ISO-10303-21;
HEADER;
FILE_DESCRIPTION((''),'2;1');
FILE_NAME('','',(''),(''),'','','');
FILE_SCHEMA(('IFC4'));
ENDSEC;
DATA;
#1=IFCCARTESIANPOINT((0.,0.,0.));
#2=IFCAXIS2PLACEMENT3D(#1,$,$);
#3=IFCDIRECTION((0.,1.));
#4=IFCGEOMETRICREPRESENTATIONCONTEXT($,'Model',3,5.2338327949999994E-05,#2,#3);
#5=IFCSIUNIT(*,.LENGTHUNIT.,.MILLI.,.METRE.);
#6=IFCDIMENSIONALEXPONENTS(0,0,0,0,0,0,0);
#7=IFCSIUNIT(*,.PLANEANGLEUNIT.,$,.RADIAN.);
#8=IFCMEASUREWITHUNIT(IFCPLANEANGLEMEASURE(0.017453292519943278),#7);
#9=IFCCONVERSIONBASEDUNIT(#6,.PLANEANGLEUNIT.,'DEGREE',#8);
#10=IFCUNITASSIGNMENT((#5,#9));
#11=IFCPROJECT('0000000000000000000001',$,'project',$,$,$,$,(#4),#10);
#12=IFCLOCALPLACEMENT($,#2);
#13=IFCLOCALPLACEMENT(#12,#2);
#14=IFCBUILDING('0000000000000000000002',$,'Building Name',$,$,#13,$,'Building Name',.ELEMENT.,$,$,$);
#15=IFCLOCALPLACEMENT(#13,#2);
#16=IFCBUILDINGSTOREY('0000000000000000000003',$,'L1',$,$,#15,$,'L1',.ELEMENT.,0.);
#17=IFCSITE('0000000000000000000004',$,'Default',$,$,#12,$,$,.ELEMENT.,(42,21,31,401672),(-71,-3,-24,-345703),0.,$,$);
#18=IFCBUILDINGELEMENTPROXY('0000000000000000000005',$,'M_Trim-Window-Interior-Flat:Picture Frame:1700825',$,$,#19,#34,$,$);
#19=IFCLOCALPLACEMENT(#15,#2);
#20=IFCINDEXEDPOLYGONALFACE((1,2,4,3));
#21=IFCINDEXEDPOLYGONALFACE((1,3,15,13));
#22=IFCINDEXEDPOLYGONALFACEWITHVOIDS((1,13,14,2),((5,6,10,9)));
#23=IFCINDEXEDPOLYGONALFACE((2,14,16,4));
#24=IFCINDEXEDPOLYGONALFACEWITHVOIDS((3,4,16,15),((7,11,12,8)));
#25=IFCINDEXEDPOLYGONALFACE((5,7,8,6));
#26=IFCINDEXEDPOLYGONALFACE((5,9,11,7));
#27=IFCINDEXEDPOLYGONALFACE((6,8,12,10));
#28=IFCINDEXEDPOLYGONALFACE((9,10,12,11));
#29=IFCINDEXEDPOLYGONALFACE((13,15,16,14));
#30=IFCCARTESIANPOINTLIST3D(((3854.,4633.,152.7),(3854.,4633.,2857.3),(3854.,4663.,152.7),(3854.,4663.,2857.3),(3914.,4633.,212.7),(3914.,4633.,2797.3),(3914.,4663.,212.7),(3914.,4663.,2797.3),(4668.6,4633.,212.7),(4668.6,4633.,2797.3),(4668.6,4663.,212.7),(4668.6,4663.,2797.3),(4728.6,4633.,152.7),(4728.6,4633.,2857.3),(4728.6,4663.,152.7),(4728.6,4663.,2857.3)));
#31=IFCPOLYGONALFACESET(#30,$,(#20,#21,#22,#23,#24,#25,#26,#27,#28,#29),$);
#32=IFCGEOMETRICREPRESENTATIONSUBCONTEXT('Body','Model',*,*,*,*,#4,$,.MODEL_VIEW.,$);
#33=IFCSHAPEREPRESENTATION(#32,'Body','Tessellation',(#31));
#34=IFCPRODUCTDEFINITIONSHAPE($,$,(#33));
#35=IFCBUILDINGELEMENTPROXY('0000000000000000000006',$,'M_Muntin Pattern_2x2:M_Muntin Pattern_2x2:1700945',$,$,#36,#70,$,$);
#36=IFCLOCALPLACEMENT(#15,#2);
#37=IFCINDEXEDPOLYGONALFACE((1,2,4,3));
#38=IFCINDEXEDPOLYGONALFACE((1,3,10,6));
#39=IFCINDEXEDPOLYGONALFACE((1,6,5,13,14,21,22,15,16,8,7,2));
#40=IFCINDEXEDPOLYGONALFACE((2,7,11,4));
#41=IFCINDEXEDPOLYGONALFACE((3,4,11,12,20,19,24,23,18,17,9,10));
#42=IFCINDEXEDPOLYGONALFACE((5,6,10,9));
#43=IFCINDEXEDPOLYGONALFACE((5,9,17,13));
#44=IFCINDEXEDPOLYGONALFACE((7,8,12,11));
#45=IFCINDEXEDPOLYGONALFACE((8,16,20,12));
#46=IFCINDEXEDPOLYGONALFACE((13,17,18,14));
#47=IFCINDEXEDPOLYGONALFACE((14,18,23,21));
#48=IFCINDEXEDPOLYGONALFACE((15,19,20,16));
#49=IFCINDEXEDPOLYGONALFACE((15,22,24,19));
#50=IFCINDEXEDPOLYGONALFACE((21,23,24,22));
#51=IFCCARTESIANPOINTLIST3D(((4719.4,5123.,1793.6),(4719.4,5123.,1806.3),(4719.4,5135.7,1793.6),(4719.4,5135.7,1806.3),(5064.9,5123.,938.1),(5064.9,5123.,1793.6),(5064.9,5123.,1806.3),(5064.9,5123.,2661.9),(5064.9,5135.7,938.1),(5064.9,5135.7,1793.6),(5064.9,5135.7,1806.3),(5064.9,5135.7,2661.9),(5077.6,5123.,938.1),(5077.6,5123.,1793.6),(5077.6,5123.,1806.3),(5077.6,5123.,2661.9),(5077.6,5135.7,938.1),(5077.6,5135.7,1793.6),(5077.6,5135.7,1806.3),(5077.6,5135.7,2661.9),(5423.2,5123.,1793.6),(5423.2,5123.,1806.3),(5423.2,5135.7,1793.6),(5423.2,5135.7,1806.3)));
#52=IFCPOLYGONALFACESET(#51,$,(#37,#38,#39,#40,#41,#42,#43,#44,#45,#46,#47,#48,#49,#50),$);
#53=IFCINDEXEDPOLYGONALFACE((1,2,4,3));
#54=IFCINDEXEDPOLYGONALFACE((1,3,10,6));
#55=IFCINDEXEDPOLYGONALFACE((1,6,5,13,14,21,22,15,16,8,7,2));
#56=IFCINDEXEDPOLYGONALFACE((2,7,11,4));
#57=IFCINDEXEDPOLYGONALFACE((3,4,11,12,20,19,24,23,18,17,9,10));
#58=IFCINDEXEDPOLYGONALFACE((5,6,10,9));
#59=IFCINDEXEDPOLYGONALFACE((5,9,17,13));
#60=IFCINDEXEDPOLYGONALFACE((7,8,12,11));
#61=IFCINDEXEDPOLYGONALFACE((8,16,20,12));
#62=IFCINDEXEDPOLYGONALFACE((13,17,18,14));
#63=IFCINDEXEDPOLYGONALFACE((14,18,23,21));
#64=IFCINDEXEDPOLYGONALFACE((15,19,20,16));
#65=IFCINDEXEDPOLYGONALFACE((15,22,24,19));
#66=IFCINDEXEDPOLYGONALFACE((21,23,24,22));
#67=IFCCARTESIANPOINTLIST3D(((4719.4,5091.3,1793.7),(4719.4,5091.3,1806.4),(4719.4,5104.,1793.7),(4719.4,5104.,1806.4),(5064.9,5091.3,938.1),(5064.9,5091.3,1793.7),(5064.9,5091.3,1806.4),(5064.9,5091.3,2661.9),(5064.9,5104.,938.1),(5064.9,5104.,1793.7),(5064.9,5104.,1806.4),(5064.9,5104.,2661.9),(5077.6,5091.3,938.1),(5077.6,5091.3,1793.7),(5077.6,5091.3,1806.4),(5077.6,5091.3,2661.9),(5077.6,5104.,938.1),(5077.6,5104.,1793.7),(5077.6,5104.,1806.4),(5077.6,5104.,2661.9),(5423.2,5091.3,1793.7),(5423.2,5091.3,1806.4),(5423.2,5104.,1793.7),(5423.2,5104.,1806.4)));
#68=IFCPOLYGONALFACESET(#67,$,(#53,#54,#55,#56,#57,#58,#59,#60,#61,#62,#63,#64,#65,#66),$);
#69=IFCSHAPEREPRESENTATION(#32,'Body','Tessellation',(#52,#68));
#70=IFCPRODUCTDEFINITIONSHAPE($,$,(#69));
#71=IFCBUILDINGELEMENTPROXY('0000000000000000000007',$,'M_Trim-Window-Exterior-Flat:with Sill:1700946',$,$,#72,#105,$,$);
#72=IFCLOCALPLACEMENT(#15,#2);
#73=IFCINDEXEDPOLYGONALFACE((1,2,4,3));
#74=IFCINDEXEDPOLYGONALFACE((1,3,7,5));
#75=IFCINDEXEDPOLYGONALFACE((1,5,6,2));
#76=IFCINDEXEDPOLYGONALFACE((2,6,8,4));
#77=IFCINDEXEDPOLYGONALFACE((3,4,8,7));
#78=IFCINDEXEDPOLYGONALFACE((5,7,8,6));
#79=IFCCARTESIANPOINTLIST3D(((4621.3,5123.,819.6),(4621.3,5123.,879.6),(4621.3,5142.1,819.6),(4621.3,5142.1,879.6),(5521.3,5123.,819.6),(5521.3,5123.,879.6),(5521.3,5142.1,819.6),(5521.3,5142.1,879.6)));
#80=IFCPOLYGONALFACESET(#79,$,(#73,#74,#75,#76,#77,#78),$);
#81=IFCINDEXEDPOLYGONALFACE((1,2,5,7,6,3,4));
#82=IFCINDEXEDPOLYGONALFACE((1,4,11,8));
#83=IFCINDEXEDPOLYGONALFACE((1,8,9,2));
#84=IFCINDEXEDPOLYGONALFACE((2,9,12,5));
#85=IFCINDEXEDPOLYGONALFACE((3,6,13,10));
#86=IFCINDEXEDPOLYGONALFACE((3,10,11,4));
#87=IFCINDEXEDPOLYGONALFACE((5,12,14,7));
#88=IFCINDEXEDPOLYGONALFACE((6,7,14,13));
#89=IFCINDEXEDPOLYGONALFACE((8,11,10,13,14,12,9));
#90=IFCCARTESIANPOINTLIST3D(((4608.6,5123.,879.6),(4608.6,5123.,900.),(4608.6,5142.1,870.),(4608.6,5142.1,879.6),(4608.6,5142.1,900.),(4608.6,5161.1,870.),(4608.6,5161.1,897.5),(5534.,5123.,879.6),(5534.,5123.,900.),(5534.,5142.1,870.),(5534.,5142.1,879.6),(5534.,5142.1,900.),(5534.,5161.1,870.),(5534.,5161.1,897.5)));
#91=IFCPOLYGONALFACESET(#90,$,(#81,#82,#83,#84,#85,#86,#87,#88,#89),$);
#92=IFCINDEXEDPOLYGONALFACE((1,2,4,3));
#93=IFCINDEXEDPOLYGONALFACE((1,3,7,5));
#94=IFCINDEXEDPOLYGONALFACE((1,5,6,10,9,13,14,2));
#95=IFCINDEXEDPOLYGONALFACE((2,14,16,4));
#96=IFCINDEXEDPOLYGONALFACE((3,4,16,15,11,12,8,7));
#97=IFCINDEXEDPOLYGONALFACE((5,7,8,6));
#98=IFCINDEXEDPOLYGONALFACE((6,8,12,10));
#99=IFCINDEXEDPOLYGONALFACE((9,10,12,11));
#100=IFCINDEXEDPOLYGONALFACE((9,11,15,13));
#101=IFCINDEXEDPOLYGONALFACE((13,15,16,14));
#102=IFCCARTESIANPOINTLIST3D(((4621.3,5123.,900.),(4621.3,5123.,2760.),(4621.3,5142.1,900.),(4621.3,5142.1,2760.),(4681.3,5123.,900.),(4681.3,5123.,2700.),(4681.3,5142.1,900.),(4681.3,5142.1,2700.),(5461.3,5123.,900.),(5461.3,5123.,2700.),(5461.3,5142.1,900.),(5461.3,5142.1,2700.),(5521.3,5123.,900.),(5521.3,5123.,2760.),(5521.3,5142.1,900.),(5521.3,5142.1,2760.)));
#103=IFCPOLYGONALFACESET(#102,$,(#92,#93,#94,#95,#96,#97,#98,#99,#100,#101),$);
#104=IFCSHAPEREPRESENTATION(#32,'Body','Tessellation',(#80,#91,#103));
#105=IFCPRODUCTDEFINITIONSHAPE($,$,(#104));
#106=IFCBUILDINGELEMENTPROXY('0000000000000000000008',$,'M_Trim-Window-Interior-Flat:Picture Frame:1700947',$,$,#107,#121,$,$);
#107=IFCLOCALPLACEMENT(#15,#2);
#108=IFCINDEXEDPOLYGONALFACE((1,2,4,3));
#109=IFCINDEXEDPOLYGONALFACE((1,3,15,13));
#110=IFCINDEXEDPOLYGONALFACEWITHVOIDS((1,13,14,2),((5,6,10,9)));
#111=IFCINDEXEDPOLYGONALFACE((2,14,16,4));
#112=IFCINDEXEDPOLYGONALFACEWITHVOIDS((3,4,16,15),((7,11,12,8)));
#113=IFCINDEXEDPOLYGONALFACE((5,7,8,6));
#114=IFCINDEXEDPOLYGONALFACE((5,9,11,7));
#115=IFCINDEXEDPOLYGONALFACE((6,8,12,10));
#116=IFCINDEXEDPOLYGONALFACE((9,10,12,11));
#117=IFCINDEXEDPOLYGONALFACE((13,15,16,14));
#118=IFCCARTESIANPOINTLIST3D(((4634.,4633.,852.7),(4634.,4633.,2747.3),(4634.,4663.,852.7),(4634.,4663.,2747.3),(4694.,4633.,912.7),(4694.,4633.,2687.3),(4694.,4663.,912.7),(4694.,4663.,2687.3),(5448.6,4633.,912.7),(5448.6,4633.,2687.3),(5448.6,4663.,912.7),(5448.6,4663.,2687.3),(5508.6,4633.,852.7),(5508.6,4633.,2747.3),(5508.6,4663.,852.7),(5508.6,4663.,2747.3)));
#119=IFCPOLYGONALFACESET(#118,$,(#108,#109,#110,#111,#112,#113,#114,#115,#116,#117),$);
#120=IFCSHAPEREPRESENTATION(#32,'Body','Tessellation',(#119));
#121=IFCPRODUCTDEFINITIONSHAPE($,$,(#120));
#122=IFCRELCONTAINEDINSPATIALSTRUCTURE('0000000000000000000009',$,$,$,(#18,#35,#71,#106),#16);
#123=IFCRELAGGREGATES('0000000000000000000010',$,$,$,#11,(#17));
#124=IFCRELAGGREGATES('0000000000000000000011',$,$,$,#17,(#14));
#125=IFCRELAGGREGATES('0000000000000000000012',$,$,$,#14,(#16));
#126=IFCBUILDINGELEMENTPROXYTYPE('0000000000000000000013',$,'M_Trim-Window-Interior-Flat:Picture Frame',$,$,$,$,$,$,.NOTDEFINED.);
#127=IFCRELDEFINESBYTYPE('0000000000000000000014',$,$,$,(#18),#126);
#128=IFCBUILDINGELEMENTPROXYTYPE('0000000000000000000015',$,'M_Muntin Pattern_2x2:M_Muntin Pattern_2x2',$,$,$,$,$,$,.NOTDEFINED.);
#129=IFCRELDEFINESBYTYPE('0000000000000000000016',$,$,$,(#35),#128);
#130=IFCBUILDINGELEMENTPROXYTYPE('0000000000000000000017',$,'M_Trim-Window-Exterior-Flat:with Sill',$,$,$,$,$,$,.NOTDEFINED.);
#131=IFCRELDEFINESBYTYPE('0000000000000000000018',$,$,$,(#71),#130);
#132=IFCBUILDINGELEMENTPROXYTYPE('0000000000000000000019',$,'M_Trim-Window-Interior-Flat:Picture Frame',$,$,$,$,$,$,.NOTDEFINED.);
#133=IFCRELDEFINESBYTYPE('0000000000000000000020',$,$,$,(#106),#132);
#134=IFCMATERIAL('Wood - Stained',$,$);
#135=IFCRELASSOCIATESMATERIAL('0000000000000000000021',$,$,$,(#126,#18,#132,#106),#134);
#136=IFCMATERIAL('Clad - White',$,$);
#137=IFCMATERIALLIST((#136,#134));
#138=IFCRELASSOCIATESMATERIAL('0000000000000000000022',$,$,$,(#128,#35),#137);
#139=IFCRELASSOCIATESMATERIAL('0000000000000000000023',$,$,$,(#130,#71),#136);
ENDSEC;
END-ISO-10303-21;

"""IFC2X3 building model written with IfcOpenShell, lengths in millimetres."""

from ifc_helpers import new_model, entity, si_unit, converted_unit, direction, frame, frame_2d, origin, place, context, subcontext, project, spatial, polyline, rectangle, outline, extrude, source, transform, mapped, material, material_list, type_object, type_shapes, element, save


model = new_model("IFC2X3")

# Units and contexts
model_context = context("Model", 3, precision=5.2338327949999994e-05, world=origin(), true_north=direction((0.0, 1.0)))
body_context = subcontext(model_context, "Body", "Model", "MODEL_VIEW")
ifc_project = project(units=[si_unit("LENGTHUNIT", "METRE", prefix="MILLI"), converted_unit("PLANEANGLEUNIT", "DEGREE", entity("IfcPlaneAngleMeasure", 0.017453292519943278), si_unit("PLANEANGLEUNIT", "RADIAN"), dimensions=[0, 0, 0, 0, 0, 0, 0])], contexts=[model_context])

# Site, building, storey
site_placement = place(None, origin())
site = spatial("IfcSite", under=ifc_project, at=site_placement, Name="Default", CompositionType="ELEMENT", RefLatitude=(42, 21, 31, 401672), RefLongitude=(-71, -3, -24, -345703), RefElevation=0.0)
building_placement = place(site_placement, origin())
building = spatial("IfcBuilding", under=site, at=building_placement, Name="Building Name", LongName="Building Name", CompositionType="ELEMENT")
storey_placement = place(building_placement, origin())
storey = spatial("IfcBuildingStorey", under=building, at=storey_placement, Name="L1", LongName="L1", CompositionType="ELEMENT", Elevation=0.0)

# Building element proxies
ifc_material_1 = material(Name="Clad - White")
ifc_material_2 = material(Name="Wood - Stained")
ifc_material_list = material_list([ifc_material_1, ifc_material_2])
building_element_proxy_type_1 = type_object("IfcBuildingElementProxyType", Name="M_Trim-Window-Interior-Flat:Picture Frame", PredefinedType="NOTDEFINED", material=ifc_material_2)
shared_shape_1 = source(origin(), body_context, "Body", "SweptSolid", [
    extrude(outline(polyline([(-437.3, -1352.3), (437.3, -1352.3), (437.3, 1352.3), (-437.3, 1352.3), (-437.3, -1352.3)]), holes=[polyline([(-377.3, -1292.3), (-377.3, 1292.3), (377.3, 1292.3), (377.3, -1292.3), (-377.3, -1292.3)])]), frame((0.0, -1305.0, 0.0), z_axis=(0.0, 0.0, 1.0), x_axis=(-1.0, 0.0, 0.0)), (0.0, 0.0, 1.0), 30.0),
])
type_shapes(building_element_proxy_type_1, [shared_shape_1])
proxy_1_placement = place(storey_placement, frame((4291.3, 4663.0, 2810.0), z_axis=(0.0, -1.0, 0.0), x_axis=(1.0, 0.0, 0.0)))
element("IfcBuildingElementProxy", 1, at=proxy_1_placement, inside=storey, type_object=building_element_proxy_type_1, material=ifc_material_2, Name="M_Trim-Window-Interior-Flat:Picture Frame:1700825", context=body_context, shape_type="MappedRepresentation", body=[
    mapped(shared_shape_1, transform((0.0, 0.0, 0.0), scale=1.0)),
])
building_element_proxy_type_2 = type_object("IfcBuildingElementProxyType", Name="M_Muntin Pattern_2x2:M_Muntin Pattern_2x2", PredefinedType="NOTDEFINED", material=ifc_material_list)
shared_shape_2 = source(origin(), body_context, "Body", "SweptSolid", [
    extrude(outline(polyline([(6.4, -6.4), (861.9, -6.4), (861.9, 6.3), (6.4, 6.3), (6.4, 351.9), (-6.3, 351.9), (-6.3, 6.3), (-861.9, 6.3), (-861.9, -6.4), (-6.3, -6.4), (-6.3, -351.9), (6.4, -351.9), (6.4, -6.4)])), frame((0.0, -22.2, 861.9), z_axis=(0.0, 1.0, 0.0), x_axis=(0.0, 0.0, 1.0)), (0.0, 0.0, 1.0), 12.7),
    extrude(outline(polyline([(6.4, -6.4), (861.9, -6.4), (861.9, 6.3), (6.4, 6.3), (6.4, 351.9), (-6.3, 351.9), (-6.3, 6.3), (-861.9, 6.3), (-861.9, -6.4), (-6.3, -6.4), (-6.3, -351.9), (6.4, -351.9), (6.4, -6.4)])), frame((0.0, 9.5, 861.9), z_axis=(0.0, 1.0, 0.0), x_axis=(0.0, 0.0, 1.0)), (0.0, 0.0, 1.0), 12.7),
])
type_shapes(building_element_proxy_type_2, [shared_shape_2])
proxy_2_placement = place(storey_placement, frame((5071.3, 5113.5, 938.1), z_axis=(0.0, 0.0, 1.0), x_axis=(-1.0, 0.0, 0.0)))
element("IfcBuildingElementProxy", 2, at=proxy_2_placement, inside=storey, type_object=building_element_proxy_type_2, material=ifc_material_list, Name="M_Muntin Pattern_2x2:M_Muntin Pattern_2x2:1700945", context=body_context, shape_type="MappedRepresentation", body=[
    mapped(shared_shape_2, transform((0.0, 0.0, 0.0), scale=1.0)),
])
building_element_proxy_type_3 = type_object("IfcBuildingElementProxyType", Name="M_Trim-Window-Exterior-Flat:with Sill", PredefinedType="NOTDEFINED", material=ifc_material_1)
shared_shape_3 = source(origin(), body_context, "Body", "SweptSolid", [
    extrude(rectangle(XDim=900.0, YDim=60.0, at=frame_2d((0.0, 0.0), x_axis=(1.0, 0.0))), frame((0.0, -1850.4, 0.0), z_axis=(0.0, 0.0, 1.0), x_axis=(-1.0, 0.0, 0.0)), (0.0, 0.0, 1.0), 19.0),
    extrude(outline(polyline([(-19.0, -15.2), (0.0, -15.2), (0.0, -5.7), (19.0, -5.7), (19.0, 14.8), (0.0, 14.8), (-19.0, 12.3), (-19.0, -15.2)])), frame((-462.7, -1814.8, 19.0), z_axis=(1.0, 0.0, 0.0), x_axis=(0.0, 0.0, -1.0)), (0.0, 0.0, 1.0), 925.4),
    extrude(outline(polyline([(-945.0, -450.0), (915.0, -450.0), (915.0, -390.0), (-885.0, -390.0), (-885.0, 390.0), (915.0, 390.0), (915.0, 450.0), (-945.0, 450.0), (-945.0, -450.0)])), frame((0.0, -885.0, 0.0), z_axis=(0.0, 0.0, 1.0), x_axis=(0.0, -1.0, 0.0)), (0.0, 0.0, 1.0), 19.0),
])
type_shapes(building_element_proxy_type_3, [shared_shape_3])
proxy_3_placement = place(storey_placement, frame((5071.3, 5123.0, 2700.0), z_axis=(0.0, 1.0, 0.0), x_axis=(-1.0, 0.0, 0.0)))
element("IfcBuildingElementProxy", 3, at=proxy_3_placement, inside=storey, type_object=building_element_proxy_type_3, material=ifc_material_1, Name="M_Trim-Window-Exterior-Flat:with Sill:1700946", context=body_context, shape_type="MappedRepresentation", body=[
    mapped(shared_shape_3, transform((0.0, 0.0, 0.0), scale=1.0)),
])
building_element_proxy_type_4 = type_object("IfcBuildingElementProxyType", Name="M_Trim-Window-Interior-Flat:Picture Frame", PredefinedType="NOTDEFINED", material=ifc_material_2)
shared_shape_4 = source(origin(), body_context, "Body", "SweptSolid", [
    extrude(outline(polyline([(-437.3, -947.3), (437.3, -947.3), (437.3, 947.3), (-437.3, 947.3), (-437.3, -947.3)]), holes=[polyline([(-377.3, -887.3), (-377.3, 887.3), (377.3, 887.3), (377.3, -887.3), (-377.3, -887.3)])]), frame((0.0, -900.0, 0.0), z_axis=(0.0, 0.0, 1.0), x_axis=(-1.0, 0.0, 0.0)), (0.0, 0.0, 1.0), 30.0),
])
type_shapes(building_element_proxy_type_4, [shared_shape_4])
proxy_4_placement = place(storey_placement, frame((5071.3, 4663.0, 2700.0), z_axis=(0.0, -1.0, 0.0), x_axis=(1.0, 0.0, 0.0)))
element("IfcBuildingElementProxy", 4, at=proxy_4_placement, inside=storey, type_object=building_element_proxy_type_4, material=ifc_material_2, Name="M_Trim-Window-Interior-Flat:Picture Frame:1700947", context=body_context, shape_type="MappedRepresentation", body=[
    mapped(shared_shape_4, transform((0.0, 0.0, 0.0), scale=1.0)),
])

save(model, "model.ifc")
